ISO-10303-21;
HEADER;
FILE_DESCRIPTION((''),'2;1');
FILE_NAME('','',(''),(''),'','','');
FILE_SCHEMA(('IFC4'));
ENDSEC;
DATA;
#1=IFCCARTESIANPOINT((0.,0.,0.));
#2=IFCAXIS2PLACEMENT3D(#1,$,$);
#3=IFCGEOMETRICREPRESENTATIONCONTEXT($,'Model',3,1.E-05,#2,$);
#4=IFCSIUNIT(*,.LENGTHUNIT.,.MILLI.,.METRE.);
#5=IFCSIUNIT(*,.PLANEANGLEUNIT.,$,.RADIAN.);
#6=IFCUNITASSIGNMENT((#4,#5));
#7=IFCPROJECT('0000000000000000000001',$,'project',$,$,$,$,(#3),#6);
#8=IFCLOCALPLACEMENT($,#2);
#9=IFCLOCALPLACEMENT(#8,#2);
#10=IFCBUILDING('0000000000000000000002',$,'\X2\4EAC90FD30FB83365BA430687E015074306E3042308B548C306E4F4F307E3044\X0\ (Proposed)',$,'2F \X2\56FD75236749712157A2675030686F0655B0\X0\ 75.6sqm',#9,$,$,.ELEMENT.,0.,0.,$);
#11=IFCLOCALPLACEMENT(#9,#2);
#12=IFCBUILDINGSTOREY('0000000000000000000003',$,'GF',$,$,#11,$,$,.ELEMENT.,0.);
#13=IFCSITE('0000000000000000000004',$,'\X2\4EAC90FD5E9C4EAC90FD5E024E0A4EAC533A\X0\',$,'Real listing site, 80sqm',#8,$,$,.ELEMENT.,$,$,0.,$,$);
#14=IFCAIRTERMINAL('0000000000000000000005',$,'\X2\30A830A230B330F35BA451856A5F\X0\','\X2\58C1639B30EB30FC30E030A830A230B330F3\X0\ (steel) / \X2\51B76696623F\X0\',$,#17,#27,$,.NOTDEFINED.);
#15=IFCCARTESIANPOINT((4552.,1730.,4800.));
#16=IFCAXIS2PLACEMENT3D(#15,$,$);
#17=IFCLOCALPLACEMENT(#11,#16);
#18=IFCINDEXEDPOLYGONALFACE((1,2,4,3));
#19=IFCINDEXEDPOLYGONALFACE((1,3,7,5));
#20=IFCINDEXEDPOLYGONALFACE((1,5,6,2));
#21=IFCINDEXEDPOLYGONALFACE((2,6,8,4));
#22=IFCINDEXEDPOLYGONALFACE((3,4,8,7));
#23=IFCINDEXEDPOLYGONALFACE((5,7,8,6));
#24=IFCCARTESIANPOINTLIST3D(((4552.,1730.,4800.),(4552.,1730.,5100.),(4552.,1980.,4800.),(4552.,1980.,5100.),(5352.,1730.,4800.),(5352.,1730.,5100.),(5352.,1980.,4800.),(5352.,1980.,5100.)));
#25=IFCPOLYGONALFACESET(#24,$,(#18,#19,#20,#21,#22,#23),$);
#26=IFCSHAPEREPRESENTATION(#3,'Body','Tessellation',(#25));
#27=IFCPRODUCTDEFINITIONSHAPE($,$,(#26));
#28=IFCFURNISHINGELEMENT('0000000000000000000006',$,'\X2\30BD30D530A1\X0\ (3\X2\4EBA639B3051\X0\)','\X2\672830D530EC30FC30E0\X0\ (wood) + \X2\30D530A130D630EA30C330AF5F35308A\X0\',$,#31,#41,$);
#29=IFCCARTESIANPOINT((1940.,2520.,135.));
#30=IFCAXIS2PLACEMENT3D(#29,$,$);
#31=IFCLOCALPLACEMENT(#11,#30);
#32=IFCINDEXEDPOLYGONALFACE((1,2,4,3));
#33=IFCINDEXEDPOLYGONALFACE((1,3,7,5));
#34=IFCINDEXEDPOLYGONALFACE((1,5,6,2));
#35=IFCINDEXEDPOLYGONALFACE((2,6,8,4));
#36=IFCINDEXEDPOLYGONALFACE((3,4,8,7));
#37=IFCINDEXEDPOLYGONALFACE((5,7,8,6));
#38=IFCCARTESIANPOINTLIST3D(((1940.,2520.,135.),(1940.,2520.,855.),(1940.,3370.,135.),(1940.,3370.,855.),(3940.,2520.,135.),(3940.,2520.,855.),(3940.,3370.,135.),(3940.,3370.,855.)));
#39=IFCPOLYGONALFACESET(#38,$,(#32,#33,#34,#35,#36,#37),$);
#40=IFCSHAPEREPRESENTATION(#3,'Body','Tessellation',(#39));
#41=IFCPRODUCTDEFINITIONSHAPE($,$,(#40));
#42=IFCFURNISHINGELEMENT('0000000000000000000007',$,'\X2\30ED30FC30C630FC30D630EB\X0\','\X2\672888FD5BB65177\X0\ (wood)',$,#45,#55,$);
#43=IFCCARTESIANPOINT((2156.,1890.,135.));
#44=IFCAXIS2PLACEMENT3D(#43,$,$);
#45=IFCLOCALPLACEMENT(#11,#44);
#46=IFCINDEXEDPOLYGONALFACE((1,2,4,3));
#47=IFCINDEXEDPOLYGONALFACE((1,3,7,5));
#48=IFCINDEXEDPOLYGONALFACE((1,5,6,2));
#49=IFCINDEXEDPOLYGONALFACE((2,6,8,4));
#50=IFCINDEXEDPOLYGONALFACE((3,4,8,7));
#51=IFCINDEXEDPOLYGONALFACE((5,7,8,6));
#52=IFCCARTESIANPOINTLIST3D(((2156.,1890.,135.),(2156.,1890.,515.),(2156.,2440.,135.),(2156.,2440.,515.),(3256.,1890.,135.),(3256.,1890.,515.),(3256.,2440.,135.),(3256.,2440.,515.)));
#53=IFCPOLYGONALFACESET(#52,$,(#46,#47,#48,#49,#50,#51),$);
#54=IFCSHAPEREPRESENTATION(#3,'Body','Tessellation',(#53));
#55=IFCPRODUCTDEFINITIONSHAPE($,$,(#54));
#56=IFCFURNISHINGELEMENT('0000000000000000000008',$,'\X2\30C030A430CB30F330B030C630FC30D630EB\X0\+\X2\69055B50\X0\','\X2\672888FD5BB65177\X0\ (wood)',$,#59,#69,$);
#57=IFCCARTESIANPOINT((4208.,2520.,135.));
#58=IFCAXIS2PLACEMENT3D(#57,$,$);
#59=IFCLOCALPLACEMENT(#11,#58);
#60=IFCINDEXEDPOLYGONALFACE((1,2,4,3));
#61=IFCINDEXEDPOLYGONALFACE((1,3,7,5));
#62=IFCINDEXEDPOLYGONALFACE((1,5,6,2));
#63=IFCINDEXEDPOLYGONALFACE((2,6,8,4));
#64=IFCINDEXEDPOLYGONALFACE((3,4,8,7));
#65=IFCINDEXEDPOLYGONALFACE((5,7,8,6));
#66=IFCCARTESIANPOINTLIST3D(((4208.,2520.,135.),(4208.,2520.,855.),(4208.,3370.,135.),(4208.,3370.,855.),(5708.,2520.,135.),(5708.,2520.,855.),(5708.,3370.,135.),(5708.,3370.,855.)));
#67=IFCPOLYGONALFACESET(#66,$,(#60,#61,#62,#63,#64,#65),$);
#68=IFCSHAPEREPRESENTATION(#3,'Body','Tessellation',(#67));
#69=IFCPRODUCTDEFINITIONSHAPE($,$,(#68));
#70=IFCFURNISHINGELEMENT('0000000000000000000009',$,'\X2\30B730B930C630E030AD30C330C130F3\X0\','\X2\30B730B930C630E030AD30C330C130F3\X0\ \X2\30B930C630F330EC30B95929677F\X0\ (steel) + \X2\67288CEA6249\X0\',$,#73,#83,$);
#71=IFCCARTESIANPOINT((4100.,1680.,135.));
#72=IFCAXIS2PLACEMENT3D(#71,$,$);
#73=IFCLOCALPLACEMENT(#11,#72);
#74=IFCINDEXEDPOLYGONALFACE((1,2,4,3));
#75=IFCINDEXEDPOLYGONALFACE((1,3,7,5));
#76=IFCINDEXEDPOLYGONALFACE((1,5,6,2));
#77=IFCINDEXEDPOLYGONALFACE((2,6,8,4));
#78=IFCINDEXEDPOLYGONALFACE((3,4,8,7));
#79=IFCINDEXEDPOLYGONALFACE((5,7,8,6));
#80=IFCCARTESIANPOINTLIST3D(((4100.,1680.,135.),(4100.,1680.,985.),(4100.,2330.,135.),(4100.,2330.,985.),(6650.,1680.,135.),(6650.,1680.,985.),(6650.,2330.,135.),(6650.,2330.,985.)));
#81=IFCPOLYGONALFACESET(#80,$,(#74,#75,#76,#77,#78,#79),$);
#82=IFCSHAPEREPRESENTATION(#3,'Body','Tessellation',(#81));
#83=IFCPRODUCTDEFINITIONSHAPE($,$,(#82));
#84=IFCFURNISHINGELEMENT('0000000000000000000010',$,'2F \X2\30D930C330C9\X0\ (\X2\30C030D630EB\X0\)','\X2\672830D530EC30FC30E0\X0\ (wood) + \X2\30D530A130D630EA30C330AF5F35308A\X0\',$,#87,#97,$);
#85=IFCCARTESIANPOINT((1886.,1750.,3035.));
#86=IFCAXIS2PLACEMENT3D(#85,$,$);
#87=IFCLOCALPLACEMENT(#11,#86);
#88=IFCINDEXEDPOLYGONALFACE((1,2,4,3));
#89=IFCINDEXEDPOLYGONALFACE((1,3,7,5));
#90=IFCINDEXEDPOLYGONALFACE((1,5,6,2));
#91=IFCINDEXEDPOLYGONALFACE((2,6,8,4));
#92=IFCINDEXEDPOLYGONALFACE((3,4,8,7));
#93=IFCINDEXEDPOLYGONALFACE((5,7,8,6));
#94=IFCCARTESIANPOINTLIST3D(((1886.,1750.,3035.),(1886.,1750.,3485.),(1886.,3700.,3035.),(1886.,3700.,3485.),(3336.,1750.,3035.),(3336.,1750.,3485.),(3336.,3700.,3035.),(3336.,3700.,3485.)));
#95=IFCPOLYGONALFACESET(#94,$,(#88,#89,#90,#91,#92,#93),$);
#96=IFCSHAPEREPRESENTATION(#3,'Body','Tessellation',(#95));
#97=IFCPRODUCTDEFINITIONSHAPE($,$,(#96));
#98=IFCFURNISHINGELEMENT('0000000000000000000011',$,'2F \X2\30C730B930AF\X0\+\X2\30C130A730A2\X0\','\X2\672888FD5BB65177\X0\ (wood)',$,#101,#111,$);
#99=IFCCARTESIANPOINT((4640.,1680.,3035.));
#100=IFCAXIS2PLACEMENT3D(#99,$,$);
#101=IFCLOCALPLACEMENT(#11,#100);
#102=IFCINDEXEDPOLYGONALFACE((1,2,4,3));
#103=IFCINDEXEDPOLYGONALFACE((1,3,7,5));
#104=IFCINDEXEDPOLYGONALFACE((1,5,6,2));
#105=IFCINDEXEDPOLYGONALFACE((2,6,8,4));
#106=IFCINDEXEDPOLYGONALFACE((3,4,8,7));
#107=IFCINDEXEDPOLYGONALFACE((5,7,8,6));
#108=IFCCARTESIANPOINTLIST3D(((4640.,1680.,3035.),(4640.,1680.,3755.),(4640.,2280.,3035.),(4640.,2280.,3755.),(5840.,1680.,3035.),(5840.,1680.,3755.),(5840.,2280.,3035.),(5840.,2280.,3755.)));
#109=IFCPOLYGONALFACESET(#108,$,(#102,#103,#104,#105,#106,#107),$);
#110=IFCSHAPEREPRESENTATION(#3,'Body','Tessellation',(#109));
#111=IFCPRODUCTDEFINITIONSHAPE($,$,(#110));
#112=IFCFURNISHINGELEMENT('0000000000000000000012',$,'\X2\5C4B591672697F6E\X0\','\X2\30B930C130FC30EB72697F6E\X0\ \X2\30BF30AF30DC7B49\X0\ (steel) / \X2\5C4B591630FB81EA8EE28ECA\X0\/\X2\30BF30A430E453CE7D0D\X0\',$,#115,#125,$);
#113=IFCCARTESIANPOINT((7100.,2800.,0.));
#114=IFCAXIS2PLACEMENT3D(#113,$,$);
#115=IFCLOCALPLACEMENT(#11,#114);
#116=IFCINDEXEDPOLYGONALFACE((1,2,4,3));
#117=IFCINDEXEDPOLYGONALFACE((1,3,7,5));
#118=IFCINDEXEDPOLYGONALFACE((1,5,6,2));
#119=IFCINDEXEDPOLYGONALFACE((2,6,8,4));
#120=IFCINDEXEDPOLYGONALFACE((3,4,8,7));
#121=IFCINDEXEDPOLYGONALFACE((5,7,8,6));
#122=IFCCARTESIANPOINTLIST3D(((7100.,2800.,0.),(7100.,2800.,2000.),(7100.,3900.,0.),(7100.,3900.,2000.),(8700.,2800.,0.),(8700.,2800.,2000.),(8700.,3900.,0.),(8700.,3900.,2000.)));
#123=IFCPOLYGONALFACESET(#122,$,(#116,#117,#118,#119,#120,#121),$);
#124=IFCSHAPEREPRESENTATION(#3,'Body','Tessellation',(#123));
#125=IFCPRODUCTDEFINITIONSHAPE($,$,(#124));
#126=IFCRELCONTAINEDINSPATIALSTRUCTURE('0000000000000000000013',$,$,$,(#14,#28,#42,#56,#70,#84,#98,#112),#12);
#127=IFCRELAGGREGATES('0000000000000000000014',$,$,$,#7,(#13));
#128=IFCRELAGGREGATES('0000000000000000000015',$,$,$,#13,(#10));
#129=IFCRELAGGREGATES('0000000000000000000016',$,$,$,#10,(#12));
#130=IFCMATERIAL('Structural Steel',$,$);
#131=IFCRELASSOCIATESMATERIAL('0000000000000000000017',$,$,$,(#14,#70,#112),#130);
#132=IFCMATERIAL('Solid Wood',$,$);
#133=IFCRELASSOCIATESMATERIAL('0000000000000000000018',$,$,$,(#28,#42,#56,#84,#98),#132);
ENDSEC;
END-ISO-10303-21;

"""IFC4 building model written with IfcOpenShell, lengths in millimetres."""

from ifc_helpers import new_model, si_unit, frame, frame_2d, origin, place, context, project, spatial, rectangle, extrude, material, element, save


model = new_model("IFC4")

# Units and contexts
model_context = context("Model", 3, precision=1e-05, world=origin())
ifc_project = project(units=[si_unit("LENGTHUNIT", "METRE", prefix="MILLI"), si_unit("PLANEANGLEUNIT", "RADIAN")], contexts=[model_context])

# Site, building, storey
site_placement = place(None, origin())
site = spatial("IfcSite", under=ifc_project, at=site_placement, Name="京都府京都市上京区", ObjectType="Real listing site, 80sqm", CompositionType="ELEMENT", RefElevation=0.0)
building_placement = place(site_placement, origin())
building = spatial("IfcBuilding", under=site, at=building_placement, Name="京都・茶室と縁側のある和の住まい (Proposed)", ObjectType="2F 国産杉無垢材と漆喰 75.6sqm", CompositionType="ELEMENT", ElevationOfRefHeight=0.0, ElevationOfTerrain=0.0)
storey_placement = place(building_placement, origin())
storey = spatial("IfcBuildingStorey", under=building, at=storey_placement, Name="GF", CompositionType="ELEMENT", Elevation=0.0)

# Shared definitions
ifc_material_1 = material(Name="Solid Wood")

# Shared definitions
ifc_material_2 = material(Name="Structural Steel")

# Air terminal
air_terminal_1_placement = place(storey_placement, frame((4552.0, 1730.0, 4800.0)))
element("IfcAirTerminal", 1, at=air_terminal_1_placement, inside=storey, material=ifc_material_2, Name="エアコン室内機", Description="壁掛ルームエアコン (steel) / 冷暖房", PredefinedType="NOTDEFINED", context=model_context, shape_type="SweptSolid", body=[
    extrude(rectangle(XDim=800.0, YDim=250.0, at=frame_2d((400.0, 125.0))), frame((4552.0, 1730.0, 4800.0)), (0.0, 0.0, 1.0), 300.0),
])

# Furnishing elements
furnishing_1_placement = place(storey_placement, frame((1940.0, 2520.0, 135.0)))
element("IfcFurnishingElement", 2, at=furnishing_1_placement, inside=storey, material=ifc_material_1, Name="ソファ (3人掛け)", Description="木フレーム (wood) + ファブリック張り", context=model_context, shape_type="SweptSolid", body=[
    extrude(rectangle(XDim=2000.0, YDim=850.0, at=frame_2d((1000.0, 425.0))), frame((1940.0, 2520.0, 135.0)), (0.0, 0.0, 1.0), 720.0),
])
furnishing_2_placement = place(storey_placement, frame((2156.0, 1890.0, 135.0)))
element("IfcFurnishingElement", 3, at=furnishing_2_placement, inside=storey, material=ifc_material_1, Name="ローテーブル", Description="木製家具 (wood)", context=model_context, shape_type="SweptSolid", body=[
    extrude(rectangle(XDim=1100.0, YDim=550.0, at=frame_2d((550.0, 275.0))), frame((2156.0, 1890.0, 135.0)), (0.0, 0.0, 1.0), 380.0),
])
furnishing_3_placement = place(storey_placement, frame((4208.0, 2520.0, 135.0)))
element("IfcFurnishingElement", 4, at=furnishing_3_placement, inside=storey, material=ifc_material_1, Name="ダイニングテーブル+椅子", Description="木製家具 (wood)", context=model_context, shape_type="SweptSolid", body=[
    extrude(rectangle(XDim=1500.0, YDim=850.0, at=frame_2d((750.0, 425.0))), frame((4208.0, 2520.0, 135.0)), (0.0, 0.0, 1.0), 720.0),
])
furnishing_4_placement = place(storey_placement, frame((4100.0, 1680.0, 135.0)))
element("IfcFurnishingElement", 5, at=furnishing_4_placement, inside=storey, material=ifc_material_2, Name="システムキッチン", Description="システムキッチン ステンレス天板 (steel) + 木質扉", context=model_context, shape_type="SweptSolid", body=[
    extrude(rectangle(XDim=2550.0, YDim=650.0, at=frame_2d((1275.0, 325.0))), frame((4100.0, 1680.0, 135.0)), (0.0, 0.0, 1.0), 850.0),
])
furnishing_5_placement = place(storey_placement, frame((1886.0, 1750.0, 3035.0)))
element("IfcFurnishingElement", 6, at=furnishing_5_placement, inside=storey, material=ifc_material_1, Name="2F ベッド (ダブル)", Description="木フレーム (wood) + ファブリック張り", context=model_context, shape_type="SweptSolid", body=[
    extrude(rectangle(XDim=1450.0, YDim=1950.0, at=frame_2d((725.0, 975.0))), frame((1886.0, 1750.0, 3035.0)), (0.0, 0.0, 1.0), 450.0),
])
furnishing_6_placement = place(storey_placement, frame((4640.0, 1680.0, 3035.0)))
element("IfcFurnishingElement", 7, at=furnishing_6_placement, inside=storey, material=ifc_material_1, Name="2F デスク+チェア", Description="木製家具 (wood)", context=model_context, shape_type="SweptSolid", body=[
    extrude(rectangle(XDim=1200.0, YDim=600.0, at=frame_2d((600.0, 300.0))), frame((4640.0, 1680.0, 3035.0)), (0.0, 0.0, 1.0), 720.0),
])
furnishing_7_placement = place(storey_placement, frame((7100.0, 2800.0, 0.0)))
element("IfcFurnishingElement", 8, at=furnishing_7_placement, inside=storey, material=ifc_material_2, Name="屋外物置", Description="スチール物置 タクボ等 (steel) / 屋外・自転車/タイヤ収納", context=model_context, shape_type="SweptSolid", body=[
    extrude(rectangle(XDim=1600.0, YDim=1100.0, at=frame_2d((800.0, 550.0))), frame((7100.0, 2800.0, 0.0)), (0.0, 0.0, 1.0), 2000.0),
])

save(model, "model.ifc")
